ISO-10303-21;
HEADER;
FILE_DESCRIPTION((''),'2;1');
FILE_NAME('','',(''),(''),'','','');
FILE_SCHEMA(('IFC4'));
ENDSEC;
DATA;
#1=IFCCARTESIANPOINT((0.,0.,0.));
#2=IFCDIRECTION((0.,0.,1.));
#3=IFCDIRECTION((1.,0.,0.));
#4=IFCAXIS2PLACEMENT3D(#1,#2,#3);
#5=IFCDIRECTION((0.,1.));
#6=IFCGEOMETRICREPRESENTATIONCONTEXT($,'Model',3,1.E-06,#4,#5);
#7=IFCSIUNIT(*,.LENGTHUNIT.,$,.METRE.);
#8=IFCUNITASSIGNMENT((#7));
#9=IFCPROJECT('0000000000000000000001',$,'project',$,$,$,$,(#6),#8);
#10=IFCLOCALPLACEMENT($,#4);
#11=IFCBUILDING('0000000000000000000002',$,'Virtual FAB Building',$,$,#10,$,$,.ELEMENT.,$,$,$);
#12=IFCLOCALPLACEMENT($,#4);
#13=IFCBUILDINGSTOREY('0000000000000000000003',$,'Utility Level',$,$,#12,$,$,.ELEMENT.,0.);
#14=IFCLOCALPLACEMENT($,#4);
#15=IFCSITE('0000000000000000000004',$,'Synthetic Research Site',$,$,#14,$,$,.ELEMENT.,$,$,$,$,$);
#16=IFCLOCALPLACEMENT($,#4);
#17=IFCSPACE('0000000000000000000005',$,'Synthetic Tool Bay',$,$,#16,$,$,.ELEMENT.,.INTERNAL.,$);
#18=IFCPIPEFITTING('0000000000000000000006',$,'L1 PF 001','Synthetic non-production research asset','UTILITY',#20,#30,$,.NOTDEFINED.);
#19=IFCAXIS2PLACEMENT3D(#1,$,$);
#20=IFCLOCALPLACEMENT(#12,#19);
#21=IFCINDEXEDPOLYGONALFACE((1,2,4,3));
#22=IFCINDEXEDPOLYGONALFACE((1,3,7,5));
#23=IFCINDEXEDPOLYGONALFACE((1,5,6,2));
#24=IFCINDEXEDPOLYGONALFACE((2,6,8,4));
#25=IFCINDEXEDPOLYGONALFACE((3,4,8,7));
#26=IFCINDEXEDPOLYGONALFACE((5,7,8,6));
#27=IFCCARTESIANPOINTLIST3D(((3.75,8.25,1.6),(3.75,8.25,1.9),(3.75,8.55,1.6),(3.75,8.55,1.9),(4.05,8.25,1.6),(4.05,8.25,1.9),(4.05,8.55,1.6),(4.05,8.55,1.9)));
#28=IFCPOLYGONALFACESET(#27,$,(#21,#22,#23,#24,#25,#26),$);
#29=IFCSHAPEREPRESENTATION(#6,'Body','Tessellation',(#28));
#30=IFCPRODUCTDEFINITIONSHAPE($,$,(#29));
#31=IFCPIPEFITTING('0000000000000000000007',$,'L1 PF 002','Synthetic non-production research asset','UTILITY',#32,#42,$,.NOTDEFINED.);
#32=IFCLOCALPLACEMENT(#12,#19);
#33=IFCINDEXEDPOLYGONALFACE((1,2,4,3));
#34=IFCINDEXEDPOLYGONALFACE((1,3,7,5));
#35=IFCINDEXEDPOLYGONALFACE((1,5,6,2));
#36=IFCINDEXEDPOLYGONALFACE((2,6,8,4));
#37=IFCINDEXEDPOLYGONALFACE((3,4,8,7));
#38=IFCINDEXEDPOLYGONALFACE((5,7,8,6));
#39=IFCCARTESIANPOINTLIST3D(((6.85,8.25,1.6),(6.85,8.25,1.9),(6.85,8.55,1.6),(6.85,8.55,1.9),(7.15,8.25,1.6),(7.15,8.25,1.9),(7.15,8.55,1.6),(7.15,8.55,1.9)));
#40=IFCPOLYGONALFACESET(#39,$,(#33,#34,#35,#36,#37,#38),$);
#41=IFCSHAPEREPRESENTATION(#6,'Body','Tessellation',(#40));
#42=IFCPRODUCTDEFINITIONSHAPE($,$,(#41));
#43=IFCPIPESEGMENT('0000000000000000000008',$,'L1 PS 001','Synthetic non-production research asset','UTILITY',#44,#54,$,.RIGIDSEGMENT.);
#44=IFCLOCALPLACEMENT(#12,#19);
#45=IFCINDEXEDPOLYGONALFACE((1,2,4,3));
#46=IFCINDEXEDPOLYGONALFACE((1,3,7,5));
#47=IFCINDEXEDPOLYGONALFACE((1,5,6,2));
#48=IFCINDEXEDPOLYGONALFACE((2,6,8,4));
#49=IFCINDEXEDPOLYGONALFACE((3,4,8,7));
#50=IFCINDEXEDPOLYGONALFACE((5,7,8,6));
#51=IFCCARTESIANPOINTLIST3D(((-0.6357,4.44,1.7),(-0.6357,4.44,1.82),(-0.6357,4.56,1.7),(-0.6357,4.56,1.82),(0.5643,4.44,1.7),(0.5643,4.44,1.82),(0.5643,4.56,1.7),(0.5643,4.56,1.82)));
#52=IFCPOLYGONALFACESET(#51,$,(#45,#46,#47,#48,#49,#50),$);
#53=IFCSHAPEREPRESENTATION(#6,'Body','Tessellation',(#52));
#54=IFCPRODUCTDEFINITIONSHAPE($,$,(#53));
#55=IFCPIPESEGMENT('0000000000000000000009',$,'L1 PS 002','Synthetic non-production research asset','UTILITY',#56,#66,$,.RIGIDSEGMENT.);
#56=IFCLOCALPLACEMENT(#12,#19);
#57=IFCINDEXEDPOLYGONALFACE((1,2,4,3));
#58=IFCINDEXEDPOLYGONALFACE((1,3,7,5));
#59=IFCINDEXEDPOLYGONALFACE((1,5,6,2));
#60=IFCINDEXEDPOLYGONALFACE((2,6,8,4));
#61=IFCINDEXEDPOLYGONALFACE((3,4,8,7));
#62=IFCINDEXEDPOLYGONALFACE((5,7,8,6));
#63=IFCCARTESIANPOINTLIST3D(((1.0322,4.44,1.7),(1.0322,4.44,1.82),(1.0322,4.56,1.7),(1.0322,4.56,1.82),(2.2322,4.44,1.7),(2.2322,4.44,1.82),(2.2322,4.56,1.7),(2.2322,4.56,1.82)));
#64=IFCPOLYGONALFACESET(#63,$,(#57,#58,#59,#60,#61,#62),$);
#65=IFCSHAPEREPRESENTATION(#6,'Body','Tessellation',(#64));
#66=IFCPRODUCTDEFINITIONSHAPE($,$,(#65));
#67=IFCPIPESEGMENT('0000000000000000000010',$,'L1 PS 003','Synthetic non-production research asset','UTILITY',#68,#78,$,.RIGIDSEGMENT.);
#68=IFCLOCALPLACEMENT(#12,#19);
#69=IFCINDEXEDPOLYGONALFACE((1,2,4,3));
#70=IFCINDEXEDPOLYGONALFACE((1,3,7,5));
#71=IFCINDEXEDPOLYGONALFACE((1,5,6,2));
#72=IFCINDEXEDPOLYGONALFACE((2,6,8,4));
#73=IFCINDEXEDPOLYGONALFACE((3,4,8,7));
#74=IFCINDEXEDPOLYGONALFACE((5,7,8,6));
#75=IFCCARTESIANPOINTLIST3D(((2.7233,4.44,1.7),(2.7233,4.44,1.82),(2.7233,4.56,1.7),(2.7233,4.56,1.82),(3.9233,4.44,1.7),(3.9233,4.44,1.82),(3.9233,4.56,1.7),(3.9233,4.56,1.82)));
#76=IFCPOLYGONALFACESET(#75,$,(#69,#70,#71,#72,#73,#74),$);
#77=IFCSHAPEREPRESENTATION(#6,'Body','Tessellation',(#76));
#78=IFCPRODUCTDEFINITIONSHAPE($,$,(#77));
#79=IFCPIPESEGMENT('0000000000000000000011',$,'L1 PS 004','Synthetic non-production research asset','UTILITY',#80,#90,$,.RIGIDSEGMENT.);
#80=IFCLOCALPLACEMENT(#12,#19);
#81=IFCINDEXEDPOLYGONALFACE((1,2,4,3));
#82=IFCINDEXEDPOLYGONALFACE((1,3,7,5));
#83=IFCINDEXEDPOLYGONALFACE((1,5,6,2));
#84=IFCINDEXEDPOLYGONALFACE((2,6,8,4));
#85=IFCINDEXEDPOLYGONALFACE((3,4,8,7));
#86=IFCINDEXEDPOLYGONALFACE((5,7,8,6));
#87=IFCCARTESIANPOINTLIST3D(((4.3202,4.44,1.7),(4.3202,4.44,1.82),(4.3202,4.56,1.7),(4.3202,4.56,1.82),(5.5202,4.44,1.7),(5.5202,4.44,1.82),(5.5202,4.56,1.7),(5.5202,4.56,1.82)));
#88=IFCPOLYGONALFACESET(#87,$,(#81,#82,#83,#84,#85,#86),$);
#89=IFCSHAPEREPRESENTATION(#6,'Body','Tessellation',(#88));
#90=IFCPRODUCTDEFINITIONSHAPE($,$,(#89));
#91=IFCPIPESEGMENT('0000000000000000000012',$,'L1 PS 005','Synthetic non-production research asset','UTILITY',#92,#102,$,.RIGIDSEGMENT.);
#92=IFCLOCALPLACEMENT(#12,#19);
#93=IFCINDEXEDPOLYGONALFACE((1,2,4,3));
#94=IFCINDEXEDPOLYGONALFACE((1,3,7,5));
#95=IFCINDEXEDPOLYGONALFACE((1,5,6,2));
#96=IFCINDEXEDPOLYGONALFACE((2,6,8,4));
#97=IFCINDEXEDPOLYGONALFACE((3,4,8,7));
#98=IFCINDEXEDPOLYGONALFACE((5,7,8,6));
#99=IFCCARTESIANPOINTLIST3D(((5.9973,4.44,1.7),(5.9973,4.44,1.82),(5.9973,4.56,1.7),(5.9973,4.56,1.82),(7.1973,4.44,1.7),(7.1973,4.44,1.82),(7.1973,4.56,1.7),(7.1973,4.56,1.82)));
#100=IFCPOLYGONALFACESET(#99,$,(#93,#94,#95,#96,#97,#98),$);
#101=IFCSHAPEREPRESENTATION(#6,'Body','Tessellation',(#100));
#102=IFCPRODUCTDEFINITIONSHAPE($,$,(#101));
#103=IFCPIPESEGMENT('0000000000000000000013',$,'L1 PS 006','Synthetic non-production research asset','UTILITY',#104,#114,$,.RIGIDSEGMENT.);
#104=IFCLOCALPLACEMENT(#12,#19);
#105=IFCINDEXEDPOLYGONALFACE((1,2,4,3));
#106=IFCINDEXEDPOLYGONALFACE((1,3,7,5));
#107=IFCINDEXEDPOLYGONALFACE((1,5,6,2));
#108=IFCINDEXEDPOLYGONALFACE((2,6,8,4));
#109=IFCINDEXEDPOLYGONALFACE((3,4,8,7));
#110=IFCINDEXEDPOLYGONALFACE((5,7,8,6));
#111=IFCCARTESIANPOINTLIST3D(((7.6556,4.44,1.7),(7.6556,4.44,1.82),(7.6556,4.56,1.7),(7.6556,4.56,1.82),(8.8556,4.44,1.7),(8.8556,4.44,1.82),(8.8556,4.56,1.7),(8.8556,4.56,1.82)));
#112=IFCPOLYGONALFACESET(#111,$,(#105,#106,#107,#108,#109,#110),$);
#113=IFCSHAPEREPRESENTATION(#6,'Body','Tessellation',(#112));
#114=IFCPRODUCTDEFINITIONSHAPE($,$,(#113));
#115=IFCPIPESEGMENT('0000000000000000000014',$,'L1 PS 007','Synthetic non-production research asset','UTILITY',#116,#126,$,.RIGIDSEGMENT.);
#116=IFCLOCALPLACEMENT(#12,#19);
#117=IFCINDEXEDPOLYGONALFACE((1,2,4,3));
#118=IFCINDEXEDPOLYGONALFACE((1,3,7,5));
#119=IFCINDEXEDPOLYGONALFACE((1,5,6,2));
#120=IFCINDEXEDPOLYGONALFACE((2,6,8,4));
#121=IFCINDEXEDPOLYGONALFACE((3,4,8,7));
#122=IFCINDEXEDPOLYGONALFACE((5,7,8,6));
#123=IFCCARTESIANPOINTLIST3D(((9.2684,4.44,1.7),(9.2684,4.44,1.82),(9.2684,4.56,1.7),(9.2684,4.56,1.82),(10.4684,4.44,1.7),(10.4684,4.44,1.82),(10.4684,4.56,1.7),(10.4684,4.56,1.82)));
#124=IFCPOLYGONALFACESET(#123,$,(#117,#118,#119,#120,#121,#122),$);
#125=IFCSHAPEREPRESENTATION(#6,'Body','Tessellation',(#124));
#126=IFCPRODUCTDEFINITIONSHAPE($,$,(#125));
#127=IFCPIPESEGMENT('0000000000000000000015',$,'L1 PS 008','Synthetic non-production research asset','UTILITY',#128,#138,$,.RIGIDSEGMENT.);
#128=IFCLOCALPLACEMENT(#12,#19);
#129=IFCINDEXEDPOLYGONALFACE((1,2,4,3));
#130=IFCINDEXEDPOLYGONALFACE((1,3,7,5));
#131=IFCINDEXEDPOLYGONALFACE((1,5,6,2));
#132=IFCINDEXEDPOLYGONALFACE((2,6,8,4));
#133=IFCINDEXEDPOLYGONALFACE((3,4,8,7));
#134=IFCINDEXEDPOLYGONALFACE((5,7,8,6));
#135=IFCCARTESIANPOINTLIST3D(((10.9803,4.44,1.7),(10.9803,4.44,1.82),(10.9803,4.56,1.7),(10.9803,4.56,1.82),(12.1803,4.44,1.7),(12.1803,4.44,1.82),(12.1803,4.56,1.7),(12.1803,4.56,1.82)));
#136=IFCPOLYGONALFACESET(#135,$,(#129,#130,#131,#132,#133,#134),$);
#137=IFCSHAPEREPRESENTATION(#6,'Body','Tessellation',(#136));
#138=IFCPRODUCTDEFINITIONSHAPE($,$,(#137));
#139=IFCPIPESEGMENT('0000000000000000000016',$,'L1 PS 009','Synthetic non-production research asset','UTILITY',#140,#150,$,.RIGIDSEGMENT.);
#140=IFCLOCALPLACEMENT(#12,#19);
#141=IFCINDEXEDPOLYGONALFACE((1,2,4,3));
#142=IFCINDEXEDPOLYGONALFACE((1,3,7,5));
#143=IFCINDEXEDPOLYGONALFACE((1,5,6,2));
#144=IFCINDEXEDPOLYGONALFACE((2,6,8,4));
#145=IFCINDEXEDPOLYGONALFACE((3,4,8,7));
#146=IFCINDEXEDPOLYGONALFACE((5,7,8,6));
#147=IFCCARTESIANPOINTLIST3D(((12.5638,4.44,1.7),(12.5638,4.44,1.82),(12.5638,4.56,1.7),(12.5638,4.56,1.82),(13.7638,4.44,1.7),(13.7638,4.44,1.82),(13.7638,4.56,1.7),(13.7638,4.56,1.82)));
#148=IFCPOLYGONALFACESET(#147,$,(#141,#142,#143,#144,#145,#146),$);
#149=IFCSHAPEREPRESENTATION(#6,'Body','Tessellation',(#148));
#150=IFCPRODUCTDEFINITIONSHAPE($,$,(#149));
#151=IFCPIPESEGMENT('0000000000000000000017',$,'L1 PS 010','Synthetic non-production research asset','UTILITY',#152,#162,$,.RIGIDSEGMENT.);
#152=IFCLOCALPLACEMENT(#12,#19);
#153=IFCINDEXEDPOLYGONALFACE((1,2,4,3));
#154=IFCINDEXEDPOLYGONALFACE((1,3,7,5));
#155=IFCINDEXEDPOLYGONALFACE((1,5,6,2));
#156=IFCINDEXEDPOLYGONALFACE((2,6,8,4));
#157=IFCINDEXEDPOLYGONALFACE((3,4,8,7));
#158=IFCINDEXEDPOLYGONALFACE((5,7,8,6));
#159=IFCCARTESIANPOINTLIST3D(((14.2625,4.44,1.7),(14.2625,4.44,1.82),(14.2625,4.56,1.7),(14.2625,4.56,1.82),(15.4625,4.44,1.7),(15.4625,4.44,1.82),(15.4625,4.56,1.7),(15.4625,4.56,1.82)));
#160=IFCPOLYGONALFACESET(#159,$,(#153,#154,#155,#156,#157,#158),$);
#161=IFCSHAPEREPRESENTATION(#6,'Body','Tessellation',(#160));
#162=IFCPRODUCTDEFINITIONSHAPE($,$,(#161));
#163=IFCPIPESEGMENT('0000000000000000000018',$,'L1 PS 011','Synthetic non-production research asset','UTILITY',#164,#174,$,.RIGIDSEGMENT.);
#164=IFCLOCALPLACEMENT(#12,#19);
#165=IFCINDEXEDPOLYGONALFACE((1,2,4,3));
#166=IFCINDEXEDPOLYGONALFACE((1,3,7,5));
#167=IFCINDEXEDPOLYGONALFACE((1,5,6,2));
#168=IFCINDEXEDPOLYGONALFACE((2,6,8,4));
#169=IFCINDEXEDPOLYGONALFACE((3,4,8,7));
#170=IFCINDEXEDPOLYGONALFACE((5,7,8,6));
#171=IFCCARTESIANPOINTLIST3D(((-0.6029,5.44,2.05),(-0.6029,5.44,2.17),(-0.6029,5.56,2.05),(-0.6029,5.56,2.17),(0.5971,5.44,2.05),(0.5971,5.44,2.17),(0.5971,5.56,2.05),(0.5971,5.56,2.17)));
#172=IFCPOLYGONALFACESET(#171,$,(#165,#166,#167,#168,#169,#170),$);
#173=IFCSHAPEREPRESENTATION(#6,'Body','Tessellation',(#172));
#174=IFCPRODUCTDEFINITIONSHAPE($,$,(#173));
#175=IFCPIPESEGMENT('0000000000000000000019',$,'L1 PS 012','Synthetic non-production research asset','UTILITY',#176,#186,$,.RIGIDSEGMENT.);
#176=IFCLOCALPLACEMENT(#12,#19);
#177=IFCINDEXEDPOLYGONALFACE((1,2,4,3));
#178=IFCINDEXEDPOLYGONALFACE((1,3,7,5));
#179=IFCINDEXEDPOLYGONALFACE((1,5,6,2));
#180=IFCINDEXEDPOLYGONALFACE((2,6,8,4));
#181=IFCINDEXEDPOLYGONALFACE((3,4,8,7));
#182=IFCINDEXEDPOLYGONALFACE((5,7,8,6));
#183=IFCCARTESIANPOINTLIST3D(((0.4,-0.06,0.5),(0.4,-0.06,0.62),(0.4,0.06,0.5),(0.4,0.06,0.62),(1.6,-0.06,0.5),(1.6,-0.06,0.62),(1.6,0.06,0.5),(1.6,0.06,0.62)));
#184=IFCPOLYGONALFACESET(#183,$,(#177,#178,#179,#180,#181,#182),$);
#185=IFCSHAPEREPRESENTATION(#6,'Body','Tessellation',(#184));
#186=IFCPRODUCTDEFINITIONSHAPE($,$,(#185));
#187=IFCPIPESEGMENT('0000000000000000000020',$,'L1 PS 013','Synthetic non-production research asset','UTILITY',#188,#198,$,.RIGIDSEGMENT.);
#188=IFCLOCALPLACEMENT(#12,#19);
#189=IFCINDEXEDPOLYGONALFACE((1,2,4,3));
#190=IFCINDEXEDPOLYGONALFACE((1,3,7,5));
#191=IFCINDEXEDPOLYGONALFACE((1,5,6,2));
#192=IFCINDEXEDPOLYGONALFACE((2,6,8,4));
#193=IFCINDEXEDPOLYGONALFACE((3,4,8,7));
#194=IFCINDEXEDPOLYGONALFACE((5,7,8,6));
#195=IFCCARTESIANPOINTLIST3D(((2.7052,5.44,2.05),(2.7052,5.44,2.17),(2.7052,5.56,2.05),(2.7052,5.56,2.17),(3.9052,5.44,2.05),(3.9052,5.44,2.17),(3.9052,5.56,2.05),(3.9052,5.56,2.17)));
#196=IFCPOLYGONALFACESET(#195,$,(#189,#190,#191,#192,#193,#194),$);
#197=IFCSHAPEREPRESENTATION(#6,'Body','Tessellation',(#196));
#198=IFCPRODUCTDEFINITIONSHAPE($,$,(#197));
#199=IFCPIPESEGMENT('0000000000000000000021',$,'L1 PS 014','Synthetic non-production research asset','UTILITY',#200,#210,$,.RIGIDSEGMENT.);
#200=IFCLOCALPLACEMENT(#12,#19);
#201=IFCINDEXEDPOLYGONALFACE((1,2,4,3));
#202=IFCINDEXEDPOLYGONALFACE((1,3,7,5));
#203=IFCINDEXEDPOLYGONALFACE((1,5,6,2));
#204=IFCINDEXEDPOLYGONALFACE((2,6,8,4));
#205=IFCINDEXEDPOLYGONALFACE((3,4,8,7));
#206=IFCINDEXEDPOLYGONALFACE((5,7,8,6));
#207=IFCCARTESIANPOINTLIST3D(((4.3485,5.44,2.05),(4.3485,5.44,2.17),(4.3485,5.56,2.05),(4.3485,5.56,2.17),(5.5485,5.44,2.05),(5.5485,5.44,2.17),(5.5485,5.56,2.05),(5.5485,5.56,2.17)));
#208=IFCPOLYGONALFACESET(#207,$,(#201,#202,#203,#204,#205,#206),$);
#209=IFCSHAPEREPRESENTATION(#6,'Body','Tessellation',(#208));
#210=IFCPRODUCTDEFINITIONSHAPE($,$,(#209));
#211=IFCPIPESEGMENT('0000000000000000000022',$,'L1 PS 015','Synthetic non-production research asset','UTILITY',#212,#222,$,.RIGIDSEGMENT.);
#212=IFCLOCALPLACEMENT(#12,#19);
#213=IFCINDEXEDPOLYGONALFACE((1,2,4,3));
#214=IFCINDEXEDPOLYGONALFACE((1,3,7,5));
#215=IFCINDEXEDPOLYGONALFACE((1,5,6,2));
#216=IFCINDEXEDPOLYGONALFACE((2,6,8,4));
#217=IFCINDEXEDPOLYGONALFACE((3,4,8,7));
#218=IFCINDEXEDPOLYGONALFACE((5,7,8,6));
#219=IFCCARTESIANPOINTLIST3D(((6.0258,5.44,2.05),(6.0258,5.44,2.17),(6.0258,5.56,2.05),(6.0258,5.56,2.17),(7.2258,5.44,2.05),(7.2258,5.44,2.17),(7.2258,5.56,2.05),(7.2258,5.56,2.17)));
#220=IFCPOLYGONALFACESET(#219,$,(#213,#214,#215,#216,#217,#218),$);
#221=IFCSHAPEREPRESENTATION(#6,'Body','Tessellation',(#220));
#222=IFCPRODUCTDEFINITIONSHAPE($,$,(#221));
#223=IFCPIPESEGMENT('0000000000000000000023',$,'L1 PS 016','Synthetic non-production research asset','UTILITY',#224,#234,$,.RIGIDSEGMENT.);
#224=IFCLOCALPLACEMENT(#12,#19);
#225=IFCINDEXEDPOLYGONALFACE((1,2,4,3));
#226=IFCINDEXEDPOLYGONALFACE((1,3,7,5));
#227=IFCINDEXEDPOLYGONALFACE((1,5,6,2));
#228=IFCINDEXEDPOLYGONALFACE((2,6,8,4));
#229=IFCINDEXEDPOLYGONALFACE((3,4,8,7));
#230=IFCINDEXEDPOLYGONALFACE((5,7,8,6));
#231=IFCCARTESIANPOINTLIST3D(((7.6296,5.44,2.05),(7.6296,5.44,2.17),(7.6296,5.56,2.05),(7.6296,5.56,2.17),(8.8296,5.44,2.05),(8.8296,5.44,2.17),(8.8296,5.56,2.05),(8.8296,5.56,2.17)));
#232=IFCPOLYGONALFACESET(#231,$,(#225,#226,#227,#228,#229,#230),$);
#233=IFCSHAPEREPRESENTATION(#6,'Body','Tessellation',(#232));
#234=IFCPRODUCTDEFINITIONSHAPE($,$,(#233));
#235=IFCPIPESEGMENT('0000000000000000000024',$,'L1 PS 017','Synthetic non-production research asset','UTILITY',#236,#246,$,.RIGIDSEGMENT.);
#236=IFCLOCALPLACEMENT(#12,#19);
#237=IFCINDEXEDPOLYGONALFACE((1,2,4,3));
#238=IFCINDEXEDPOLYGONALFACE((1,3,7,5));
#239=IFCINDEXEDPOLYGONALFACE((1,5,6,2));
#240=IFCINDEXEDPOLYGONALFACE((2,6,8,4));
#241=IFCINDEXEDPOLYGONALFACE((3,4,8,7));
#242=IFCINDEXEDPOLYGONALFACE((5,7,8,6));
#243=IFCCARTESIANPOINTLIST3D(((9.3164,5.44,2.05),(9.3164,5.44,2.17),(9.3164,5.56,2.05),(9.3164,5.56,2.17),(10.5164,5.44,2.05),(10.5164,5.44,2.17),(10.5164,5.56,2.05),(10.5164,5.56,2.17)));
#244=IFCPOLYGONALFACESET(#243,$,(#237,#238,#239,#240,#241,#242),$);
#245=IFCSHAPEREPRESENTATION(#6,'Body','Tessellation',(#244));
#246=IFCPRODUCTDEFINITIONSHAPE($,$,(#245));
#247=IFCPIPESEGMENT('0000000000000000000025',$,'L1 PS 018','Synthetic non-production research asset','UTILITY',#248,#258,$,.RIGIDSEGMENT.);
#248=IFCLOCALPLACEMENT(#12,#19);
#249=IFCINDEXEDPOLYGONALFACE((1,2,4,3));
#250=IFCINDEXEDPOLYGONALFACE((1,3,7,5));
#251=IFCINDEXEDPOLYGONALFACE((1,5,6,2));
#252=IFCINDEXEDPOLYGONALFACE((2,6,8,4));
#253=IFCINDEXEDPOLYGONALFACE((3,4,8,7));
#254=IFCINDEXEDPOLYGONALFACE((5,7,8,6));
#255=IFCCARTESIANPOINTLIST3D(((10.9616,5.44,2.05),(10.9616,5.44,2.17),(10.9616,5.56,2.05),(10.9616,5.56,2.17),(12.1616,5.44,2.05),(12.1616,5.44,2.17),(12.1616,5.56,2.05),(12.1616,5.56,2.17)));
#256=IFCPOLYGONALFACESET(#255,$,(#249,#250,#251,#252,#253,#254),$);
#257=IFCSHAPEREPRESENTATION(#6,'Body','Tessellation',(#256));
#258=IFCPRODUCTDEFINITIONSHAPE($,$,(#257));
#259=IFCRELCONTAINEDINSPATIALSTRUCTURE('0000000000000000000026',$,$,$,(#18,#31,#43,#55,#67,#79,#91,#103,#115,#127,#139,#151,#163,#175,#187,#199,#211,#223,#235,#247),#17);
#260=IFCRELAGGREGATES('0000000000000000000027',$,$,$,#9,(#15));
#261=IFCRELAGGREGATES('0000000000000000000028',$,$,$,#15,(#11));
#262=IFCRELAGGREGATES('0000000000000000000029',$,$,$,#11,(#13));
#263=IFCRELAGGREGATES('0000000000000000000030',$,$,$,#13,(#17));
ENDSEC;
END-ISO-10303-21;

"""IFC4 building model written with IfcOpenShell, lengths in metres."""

from ifc_helpers import new_model, si_unit, direction, frame, origin_with_axes, origin_2d_with_axis, place, context, project, spatial, rectangle, extrude, element, save


model = new_model("IFC4")

# Units and contexts
model_context = context("Model", 3, precision=1e-06, world=origin_with_axes(), true_north=direction((0.0, 1.0)))
ifc_project = project(units=[si_unit("LENGTHUNIT", "METRE")], contexts=[model_context])

# Site, building, storey, space
site_placement = place(None, origin_with_axes())
site = spatial("IfcSite", under=ifc_project, at=site_placement, Name="Synthetic Research Site", CompositionType="ELEMENT")
building_placement = place(None, origin_with_axes())
building = spatial("IfcBuilding", under=site, at=building_placement, Name="Virtual FAB Building", CompositionType="ELEMENT")
storey_placement = place(None, origin_with_axes())
storey = spatial("IfcBuildingStorey", under=building, at=storey_placement, Name="Utility Level", CompositionType="ELEMENT", Elevation=0.0)
space_placement = place(None, origin_with_axes())
space = spatial("IfcSpace", under=storey, at=space_placement, Name="Synthetic Tool Bay", CompositionType="ELEMENT", PredefinedType="INTERNAL")

# Pipe fittings
for number, where, z_axis, x_axis, name in (
    (1, (3.9, 8.4, 1.6), (0.0, 0.0, 1.0), (1.0, 0.0, 0.0), "L1 PF 001"),
    (2, (7.0, 8.4, 1.6), (0.0, 0.0, 1.0), (1.0, 0.0, 0.0), "L1 PF 002"),
):
    element("IfcPipeFitting", number, at=place(None, frame(where, z_axis=z_axis, x_axis=x_axis)), inside=space, Name=name, Description="Synthetic non-production research asset", ObjectType="UTILITY", PredefinedType="NOTDEFINED", context=model_context, shape_type="SweptSolid", body=[
        extrude(rectangle(XDim=0.3, YDim=0.3, at=origin_2d_with_axis()), origin_with_axes(), (0.0, 0.0, 1.0), 0.3),
    ])

# Pipe segments
for number, where, z_axis, x_axis, name in (
    (3, (-0.0357, 4.5, 1.7), (0.0, 0.0, 1.0), (1.0, 0.0, 0.0), "L1 PS 001"),
    (4, (1.6322, 4.5, 1.7), (0.0, 0.0, 1.0), (1.0, 0.0, 0.0), "L1 PS 002"),
    (5, (3.3233, 4.5, 1.7), (0.0, 0.0, 1.0), (1.0, 0.0, 0.0), "L1 PS 003"),
    (6, (4.9202, 4.5, 1.7), (0.0, 0.0, 1.0), (1.0, 0.0, 0.0), "L1 PS 004"),
    (7, (6.5973, 4.5, 1.7), (0.0, 0.0, 1.0), (1.0, 0.0, 0.0), "L1 PS 005"),
    (8, (8.2556, 4.5, 1.7), (0.0, 0.0, 1.0), (1.0, 0.0, 0.0), "L1 PS 006"),
    (9, (9.8684, 4.5, 1.7), (0.0, 0.0, 1.0), (1.0, 0.0, 0.0), "L1 PS 007"),
    (10, (11.5803, 4.5, 1.7), (0.0, 0.0, 1.0), (1.0, 0.0, 0.0), "L1 PS 008"),
    (11, (13.1638, 4.5, 1.7), (0.0, 0.0, 1.0), (1.0, 0.0, 0.0), "L1 PS 009"),
    (12, (14.8625, 4.5, 1.7), (0.0, 0.0, 1.0), (1.0, 0.0, 0.0), "L1 PS 010"),
    (13, (-0.0029, 5.5, 2.05), (0.0, 0.0, 1.0), (1.0, 0.0, 0.0), "L1 PS 011"),
    (14, (1.0, 0.0, 0.5), (0.0, 0.0, 1.0), (1.0, 0.0, 0.0), "L1 PS 012"),
    (15, (3.3053, 5.5, 2.05), (0.0, 0.0, 1.0), (1.0, 0.0, 0.0), "L1 PS 013"),
    (16, (4.9485, 5.5, 2.05), (0.0, 0.0, 1.0), (1.0, 0.0, 0.0), "L1 PS 014"),
    (17, (6.6258, 5.5, 2.05), (0.0, 0.0, 1.0), (1.0, 0.0, 0.0), "L1 PS 015"),
    (18, (8.2296, 5.5, 2.05), (0.0, 0.0, 1.0), (1.0, 0.0, 0.0), "L1 PS 016"),
    (19, (9.9164, 5.5, 2.05), (0.0, 0.0, 1.0), (1.0, 0.0, 0.0), "L1 PS 017"),
    (20, (11.5616, 5.5, 2.05), (0.0, 0.0, 1.0), (1.0, 0.0, 0.0), "L1 PS 018"),
):
    element("IfcPipeSegment", number, at=place(None, frame(where, z_axis=z_axis, x_axis=x_axis)), inside=space, Name=name, Description="Synthetic non-production research asset", ObjectType="UTILITY", PredefinedType="RIGIDSEGMENT", context=model_context, shape_type="SweptSolid", body=[
        extrude(rectangle(XDim=1.2, YDim=0.12, at=origin_2d_with_axis()), origin_with_axes(), (0.0, 0.0, 1.0), 0.12),
    ])

save(model, "model.ifc")
